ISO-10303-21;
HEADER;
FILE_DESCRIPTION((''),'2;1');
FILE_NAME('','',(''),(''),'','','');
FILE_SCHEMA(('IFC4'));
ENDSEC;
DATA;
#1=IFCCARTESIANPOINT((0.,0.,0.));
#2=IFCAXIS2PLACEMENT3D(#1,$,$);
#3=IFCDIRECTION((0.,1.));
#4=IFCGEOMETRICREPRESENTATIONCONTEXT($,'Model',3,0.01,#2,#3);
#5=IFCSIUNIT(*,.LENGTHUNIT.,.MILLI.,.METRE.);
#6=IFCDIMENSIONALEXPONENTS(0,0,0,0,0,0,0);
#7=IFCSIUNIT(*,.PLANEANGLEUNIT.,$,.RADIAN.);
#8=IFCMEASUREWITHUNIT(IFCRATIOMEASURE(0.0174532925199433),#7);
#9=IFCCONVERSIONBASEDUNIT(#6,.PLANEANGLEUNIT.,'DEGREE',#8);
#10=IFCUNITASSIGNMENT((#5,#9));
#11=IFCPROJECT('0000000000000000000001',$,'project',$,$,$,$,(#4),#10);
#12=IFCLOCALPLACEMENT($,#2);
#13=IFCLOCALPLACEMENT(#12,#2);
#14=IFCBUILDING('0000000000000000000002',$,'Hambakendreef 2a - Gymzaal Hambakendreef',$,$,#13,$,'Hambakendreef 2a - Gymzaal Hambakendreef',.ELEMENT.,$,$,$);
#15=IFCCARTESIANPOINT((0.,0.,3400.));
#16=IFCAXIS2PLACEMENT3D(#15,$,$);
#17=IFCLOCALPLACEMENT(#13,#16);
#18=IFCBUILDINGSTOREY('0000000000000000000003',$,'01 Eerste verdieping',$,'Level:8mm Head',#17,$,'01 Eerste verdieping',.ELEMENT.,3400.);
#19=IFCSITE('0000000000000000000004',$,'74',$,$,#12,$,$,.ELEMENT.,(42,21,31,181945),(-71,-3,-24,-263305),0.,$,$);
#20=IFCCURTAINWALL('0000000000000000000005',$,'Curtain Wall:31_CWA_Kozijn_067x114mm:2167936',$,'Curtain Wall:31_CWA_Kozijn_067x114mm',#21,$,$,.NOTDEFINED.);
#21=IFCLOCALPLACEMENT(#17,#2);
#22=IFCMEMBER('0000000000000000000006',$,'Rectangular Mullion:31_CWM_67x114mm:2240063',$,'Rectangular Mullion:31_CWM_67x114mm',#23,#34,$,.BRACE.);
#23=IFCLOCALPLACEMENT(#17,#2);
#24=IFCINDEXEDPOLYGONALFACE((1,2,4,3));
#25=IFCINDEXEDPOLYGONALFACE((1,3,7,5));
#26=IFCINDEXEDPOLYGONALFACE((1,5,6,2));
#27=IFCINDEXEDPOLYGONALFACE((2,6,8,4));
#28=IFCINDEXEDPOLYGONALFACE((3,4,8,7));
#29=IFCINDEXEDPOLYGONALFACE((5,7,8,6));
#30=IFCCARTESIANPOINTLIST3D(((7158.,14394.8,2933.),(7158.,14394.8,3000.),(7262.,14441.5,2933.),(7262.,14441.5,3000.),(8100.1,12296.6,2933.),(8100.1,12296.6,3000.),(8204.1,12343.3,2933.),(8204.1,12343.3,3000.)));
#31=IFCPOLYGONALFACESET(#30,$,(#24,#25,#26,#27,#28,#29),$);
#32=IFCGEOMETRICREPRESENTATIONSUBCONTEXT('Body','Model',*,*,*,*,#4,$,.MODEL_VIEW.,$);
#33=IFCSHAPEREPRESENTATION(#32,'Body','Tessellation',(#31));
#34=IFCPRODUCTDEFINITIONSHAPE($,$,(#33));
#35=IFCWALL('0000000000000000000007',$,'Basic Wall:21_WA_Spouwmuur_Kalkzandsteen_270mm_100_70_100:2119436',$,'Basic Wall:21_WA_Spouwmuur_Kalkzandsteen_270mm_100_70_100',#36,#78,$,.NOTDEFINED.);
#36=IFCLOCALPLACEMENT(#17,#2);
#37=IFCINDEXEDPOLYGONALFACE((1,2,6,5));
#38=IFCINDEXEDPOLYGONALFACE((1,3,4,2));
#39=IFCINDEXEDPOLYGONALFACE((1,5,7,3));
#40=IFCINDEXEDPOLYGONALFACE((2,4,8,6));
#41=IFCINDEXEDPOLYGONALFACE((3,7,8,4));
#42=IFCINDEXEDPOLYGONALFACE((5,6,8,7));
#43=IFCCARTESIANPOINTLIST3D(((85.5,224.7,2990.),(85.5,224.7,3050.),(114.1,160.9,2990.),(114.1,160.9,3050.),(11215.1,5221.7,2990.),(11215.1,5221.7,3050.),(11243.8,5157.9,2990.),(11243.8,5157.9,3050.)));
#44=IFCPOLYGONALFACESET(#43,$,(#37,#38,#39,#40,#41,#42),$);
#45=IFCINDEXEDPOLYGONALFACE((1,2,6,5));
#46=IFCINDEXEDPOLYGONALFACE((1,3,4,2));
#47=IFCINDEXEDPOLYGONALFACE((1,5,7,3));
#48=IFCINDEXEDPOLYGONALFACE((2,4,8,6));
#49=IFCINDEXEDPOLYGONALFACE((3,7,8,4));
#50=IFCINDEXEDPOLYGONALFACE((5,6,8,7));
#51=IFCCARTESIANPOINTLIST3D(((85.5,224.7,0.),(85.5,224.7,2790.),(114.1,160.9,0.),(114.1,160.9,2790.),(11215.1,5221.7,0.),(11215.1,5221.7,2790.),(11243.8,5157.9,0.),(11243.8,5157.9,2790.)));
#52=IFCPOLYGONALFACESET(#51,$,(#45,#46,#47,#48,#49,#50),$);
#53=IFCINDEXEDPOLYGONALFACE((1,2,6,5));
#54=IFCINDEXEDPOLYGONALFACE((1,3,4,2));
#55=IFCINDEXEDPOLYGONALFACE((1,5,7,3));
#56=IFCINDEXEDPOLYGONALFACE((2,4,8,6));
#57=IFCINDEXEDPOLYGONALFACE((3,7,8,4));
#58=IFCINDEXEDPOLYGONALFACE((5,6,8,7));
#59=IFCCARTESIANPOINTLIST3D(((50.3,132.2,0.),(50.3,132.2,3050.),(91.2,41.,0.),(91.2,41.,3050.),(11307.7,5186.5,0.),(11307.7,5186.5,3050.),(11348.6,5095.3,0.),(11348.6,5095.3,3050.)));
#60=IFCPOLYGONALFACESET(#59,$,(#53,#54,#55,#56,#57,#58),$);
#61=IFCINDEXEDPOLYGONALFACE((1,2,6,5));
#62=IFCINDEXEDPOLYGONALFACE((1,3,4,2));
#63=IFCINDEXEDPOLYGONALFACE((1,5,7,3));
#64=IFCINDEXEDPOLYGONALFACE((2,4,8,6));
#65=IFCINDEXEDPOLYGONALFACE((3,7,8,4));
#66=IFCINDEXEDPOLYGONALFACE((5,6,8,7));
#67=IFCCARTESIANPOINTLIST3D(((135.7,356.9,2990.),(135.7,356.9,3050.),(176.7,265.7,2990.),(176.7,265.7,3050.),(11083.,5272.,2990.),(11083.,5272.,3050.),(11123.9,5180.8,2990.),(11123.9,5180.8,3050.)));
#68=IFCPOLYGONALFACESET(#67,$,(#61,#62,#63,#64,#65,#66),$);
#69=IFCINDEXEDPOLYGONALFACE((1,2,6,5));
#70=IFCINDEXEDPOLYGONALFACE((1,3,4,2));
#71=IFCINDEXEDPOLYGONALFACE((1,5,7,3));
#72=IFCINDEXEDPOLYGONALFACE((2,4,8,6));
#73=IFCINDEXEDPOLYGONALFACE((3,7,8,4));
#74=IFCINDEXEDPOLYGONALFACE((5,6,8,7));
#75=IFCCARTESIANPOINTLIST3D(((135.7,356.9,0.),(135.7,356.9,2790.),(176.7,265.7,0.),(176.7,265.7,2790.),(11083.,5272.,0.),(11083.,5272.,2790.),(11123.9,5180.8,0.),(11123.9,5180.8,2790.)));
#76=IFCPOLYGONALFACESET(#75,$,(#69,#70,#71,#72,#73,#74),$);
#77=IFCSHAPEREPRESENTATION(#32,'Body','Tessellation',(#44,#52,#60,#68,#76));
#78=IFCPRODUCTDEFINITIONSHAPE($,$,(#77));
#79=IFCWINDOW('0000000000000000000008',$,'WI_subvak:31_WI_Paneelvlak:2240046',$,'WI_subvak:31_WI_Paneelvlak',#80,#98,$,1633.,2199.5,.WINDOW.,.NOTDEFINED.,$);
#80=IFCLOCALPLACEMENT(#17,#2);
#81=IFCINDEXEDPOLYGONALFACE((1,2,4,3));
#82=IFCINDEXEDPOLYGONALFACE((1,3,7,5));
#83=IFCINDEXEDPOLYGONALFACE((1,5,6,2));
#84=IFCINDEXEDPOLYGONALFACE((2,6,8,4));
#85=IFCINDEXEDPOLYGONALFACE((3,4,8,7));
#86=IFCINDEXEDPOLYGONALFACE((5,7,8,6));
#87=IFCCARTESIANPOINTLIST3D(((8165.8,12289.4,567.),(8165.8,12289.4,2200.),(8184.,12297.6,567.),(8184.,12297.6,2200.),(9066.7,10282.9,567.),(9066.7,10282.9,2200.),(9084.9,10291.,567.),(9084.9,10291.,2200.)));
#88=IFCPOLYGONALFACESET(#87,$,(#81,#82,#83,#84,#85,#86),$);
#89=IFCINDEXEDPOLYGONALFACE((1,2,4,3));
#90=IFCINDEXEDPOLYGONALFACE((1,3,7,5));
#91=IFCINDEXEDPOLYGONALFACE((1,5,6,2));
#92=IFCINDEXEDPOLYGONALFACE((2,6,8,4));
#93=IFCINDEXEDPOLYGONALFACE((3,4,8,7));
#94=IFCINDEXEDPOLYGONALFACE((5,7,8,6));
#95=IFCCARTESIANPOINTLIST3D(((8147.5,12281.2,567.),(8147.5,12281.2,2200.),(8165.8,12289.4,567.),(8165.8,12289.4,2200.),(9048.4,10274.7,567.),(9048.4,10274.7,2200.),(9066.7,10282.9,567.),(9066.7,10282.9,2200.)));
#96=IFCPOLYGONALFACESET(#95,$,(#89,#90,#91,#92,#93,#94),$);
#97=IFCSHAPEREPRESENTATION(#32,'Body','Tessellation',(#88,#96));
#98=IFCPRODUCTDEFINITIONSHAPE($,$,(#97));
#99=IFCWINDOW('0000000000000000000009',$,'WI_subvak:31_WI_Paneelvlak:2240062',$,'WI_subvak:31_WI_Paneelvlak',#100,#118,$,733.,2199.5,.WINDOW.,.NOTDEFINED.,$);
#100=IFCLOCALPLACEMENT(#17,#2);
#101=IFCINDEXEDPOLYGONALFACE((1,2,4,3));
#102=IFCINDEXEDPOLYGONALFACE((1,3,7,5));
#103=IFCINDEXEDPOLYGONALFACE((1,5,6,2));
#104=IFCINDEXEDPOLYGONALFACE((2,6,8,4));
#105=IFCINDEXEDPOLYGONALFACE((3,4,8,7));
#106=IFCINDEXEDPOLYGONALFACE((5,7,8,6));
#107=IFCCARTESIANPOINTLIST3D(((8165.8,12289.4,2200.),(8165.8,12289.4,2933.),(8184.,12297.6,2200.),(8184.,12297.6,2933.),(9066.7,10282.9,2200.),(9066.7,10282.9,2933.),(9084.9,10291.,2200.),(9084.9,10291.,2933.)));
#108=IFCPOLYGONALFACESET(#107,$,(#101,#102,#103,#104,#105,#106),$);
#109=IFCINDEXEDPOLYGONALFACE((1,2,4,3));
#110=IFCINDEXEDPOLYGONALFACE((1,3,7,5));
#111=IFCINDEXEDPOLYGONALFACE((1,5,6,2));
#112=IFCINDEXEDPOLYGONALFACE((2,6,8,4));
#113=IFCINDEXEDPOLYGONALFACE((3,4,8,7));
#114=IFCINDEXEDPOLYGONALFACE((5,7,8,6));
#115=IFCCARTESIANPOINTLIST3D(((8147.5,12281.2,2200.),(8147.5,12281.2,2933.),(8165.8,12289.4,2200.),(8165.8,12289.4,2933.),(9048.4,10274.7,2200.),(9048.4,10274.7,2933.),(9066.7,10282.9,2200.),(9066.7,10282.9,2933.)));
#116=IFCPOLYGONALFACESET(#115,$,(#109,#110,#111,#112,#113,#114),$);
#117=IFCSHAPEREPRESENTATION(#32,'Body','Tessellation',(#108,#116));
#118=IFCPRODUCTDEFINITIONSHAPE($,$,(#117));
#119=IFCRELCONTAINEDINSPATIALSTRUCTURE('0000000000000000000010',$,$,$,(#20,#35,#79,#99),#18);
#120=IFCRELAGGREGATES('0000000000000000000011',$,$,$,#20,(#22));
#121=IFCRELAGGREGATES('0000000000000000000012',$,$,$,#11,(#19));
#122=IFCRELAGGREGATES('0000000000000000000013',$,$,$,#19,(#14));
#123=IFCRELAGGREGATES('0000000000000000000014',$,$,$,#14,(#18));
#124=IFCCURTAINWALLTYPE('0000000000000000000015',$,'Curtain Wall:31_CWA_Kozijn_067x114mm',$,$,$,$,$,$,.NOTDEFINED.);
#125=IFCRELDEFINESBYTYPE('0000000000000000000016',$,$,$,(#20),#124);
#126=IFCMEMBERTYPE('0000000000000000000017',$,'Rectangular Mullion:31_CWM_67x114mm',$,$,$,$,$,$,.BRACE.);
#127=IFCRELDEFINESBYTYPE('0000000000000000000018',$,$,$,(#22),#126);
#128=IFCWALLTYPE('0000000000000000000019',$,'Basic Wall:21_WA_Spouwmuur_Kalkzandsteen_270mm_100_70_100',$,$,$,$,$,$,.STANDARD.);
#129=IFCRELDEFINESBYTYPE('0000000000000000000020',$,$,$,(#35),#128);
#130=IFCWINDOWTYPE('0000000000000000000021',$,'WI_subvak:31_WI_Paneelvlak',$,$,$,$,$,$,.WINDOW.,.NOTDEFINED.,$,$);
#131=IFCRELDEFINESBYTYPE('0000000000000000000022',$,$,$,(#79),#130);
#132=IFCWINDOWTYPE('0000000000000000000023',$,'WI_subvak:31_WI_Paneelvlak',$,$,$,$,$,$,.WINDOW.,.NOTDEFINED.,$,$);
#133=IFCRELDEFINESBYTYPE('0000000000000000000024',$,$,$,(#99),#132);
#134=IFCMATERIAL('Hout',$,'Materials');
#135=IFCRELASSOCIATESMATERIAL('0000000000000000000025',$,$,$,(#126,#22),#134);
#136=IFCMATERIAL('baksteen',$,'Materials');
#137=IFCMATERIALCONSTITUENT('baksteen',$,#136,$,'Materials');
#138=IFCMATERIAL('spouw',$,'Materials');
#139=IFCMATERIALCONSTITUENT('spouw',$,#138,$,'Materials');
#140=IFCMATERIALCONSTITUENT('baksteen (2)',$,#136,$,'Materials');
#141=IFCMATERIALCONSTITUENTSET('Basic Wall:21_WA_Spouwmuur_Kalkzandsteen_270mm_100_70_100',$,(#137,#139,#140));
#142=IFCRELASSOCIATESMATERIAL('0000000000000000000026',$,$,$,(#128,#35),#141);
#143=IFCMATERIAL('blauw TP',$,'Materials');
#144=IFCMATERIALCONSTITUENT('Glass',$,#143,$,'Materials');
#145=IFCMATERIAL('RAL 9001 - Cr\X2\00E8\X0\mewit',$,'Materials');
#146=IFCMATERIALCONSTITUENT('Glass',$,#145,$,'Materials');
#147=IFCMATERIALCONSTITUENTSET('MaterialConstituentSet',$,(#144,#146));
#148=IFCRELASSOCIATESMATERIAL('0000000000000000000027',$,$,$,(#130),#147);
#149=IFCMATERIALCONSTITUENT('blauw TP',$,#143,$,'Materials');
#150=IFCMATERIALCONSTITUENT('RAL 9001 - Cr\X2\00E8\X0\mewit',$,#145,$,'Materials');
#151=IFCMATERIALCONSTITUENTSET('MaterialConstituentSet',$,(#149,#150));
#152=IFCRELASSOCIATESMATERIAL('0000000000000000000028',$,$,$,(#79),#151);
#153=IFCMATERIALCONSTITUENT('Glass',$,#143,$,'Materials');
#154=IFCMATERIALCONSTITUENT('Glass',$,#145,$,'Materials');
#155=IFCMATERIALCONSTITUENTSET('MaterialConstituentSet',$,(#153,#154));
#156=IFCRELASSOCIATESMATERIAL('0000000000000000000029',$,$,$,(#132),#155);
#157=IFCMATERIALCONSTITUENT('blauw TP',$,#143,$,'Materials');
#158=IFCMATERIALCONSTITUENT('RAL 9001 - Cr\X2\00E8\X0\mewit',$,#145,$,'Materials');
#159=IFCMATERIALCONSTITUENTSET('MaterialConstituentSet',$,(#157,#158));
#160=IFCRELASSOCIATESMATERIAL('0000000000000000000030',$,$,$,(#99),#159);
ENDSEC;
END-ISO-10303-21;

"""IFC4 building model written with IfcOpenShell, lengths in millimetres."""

from ifc_helpers import new_model, entity, si_unit, converted_unit, direction, frame, origin, place, context, subcontext, project, spatial, indexed_curve, outline, extrude, source, transform, mapped, material, constituent, constituent_set, type_object, type_shapes, element, aggregate, save


model = new_model("IFC4")

# Units and contexts
model_context = context("Model", 3, precision=0.01, world=origin(), true_north=direction((0.0, 1.0)))
body_context = subcontext(model_context, "Body", "Model", "MODEL_VIEW")
ifc_project = project(units=[si_unit("LENGTHUNIT", "METRE", prefix="MILLI"), converted_unit("PLANEANGLEUNIT", "DEGREE", entity("IfcRatioMeasure", 0.0174532925199433), si_unit("PLANEANGLEUNIT", "RADIAN"), dimensions=[0, 0, 0, 0, 0, 0, 0])], contexts=[model_context])

# Site, building, storey
site_placement = place(None, origin())
site = spatial("IfcSite", under=ifc_project, at=site_placement, Name="74", CompositionType="ELEMENT", RefLatitude=(42, 21, 31, 181945), RefLongitude=(-71, -3, -24, -263305), RefElevation=0.0)
building_placement = place(site_placement, origin())
building = spatial("IfcBuilding", under=site, at=building_placement, Name="Hambakendreef 2a - Gymzaal Hambakendreef", LongName="Hambakendreef 2a - Gymzaal Hambakendreef", CompositionType="ELEMENT")
storey_placement = place(building_placement, frame((0.0, 0.0, 3400.0)))
storey = spatial("IfcBuildingStorey", under=building, at=storey_placement, Name="01 Eerste verdieping", ObjectType="Level:8mm Head", LongName="01 Eerste verdieping", CompositionType="ELEMENT", Elevation=3400.0)

# Curtain wall, member
curtain_wall_type = type_object("IfcCurtainWallType", Name="Curtain Wall:31_CWA_Kozijn_067x114mm", PredefinedType="NOTDEFINED")
ifc_material_1 = material(Name="Hout", Category="Materials")
curtain_wall_1_placement = place(storey_placement, frame((0.0, 0.0, -3400.0)))
curtain_wall_1 = element("IfcCurtainWall", 1, at=curtain_wall_1_placement, inside=storey, type_object=curtain_wall_type, Name="Curtain Wall:31_CWA_Kozijn_067x114mm:2167936", ObjectType="Curtain Wall:31_CWA_Kozijn_067x114mm", PredefinedType="NOTDEFINED")
member_type_1 = type_object("IfcMemberType", Name="Rectangular Mullion:31_CWM_67x114mm", PredefinedType="BRACE", material=ifc_material_1)
shared_shape_1 = source(origin(), body_context, "Body", "SweptSolid", [
    extrude(outline(indexed_curve([(-57.0, -33.5), (57.0, -33.5), (57.0, 33.5), (-57.0, 33.5), (-57.0, -33.5)], self_intersect=False)), frame((-33.5, 0.0, -2300.0), z_axis=(0.0, 0.0, 1.0), x_axis=(0.0, -1.0, 0.0)), (0.0, 0.0, 1.0), 2300.0),
])
type_shapes(member_type_1, [shared_shape_1])
member_1_placement = place(storey_placement, frame((8152.1, 12319.9, 3000.0), z_axis=(0.40959, -0.91227, 0.0), x_axis=(0.0, 0.0, 1.0)))
member_1 = element("IfcMember", 2, at=member_1_placement, type_object=member_type_1, material=ifc_material_1, Name="Rectangular Mullion:31_CWM_67x114mm:2240063", ObjectType="Rectangular Mullion:31_CWM_67x114mm", PredefinedType="BRACE", context=body_context, shape_type="MappedRepresentation", body=[
    mapped(shared_shape_1, transform((0.0, 0.0, 0.0), scale=1.0)),
])
aggregate(curtain_wall_1, [member_1])

# Wall
ifc_material_2 = material(Name="baksteen", Category="Materials")
ifc_constituent_1 = constituent(ifc_material_2, Name="baksteen", Category="Materials")
ifc_material_3 = material(Name="spouw", Category="Materials")
ifc_constituent_2 = constituent(ifc_material_3, Name="spouw", Category="Materials")
ifc_constituent_3 = constituent(ifc_material_2, Name="baksteen (2)", Category="Materials")
ifc_constituent_set_1 = constituent_set(constituents=[ifc_constituent_1, ifc_constituent_2, ifc_constituent_3], Name="Basic Wall:21_WA_Spouwmuur_Kalkzandsteen_270mm_100_70_100")
wall_type = type_object("IfcWallType", Name="Basic Wall:21_WA_Spouwmuur_Kalkzandsteen_270mm_100_70_100", PredefinedType="STANDARD", material=ifc_constituent_set_1)
wall_placement = place(storey_placement, frame((11138.3, 5148.8, 0.0), z_axis=(0.0, 0.0, 1.0), x_axis=(-0.91227, -0.40959, 0.0)))
element("IfcWall", 3, at=wall_placement, inside=storey, type_object=wall_type, material=ifc_constituent_set_1, Name="Basic Wall:21_WA_Spouwmuur_Kalkzandsteen_270mm_100_70_100:2119436", ObjectType="Basic Wall:21_WA_Spouwmuur_Kalkzandsteen_270mm_100_70_100", PredefinedType="NOTDEFINED", context=body_context, shape_type="SweptSolid", body=[
    extrude(outline(indexed_curve([(-6100.0, -35.0), (6100.0, -35.0), (6100.0, 35.0), (-6100.0, 35.0), (-6100.0, -35.0)], self_intersect=False)), frame((6000.0, 0.0, 2990.0), z_axis=(0.0, 0.0, 1.0), x_axis=(-1.0, 0.0, 0.0)), (0.0, 0.0, 1.0), 60.0),
    extrude(outline(indexed_curve([(-6100.0, -35.0), (6100.0, -35.0), (6100.0, 35.0), (-6100.0, 35.0), (-6100.0, -35.0)], self_intersect=False)), frame((6000.0, 0.0, 0.0)), (0.0, 0.0, 1.0), 2790.0),
    extrude(outline(indexed_curve([(-50.0, -6170.0), (50.0, -6170.0), (50.0, 6170.0), (-50.0, 6170.0), (-50.0, -6170.0)], self_intersect=False)), frame((6000.0, 85.0, 0.0), z_axis=(0.0, 0.0, 1.0), x_axis=(0.0, -1.0, 0.0)), (0.0, 0.0, 1.0), 3050.0),
    extrude(outline(indexed_curve([(-50.0, -6000.0), (50.0, -6000.0), (50.0, 6000.0), (-50.0, 6000.0), (-50.0, -6000.0)], self_intersect=False)), frame((6000.0, -85.0, 2990.0), z_axis=(0.0, 0.0, 1.0), x_axis=(0.0, 1.0, 0.0)), (0.0, 0.0, 1.0), 60.0),
    extrude(outline(indexed_curve([(-50.0, -6000.0), (50.0, -6000.0), (50.0, 6000.0), (-50.0, 6000.0), (-50.0, -6000.0)], self_intersect=False)), frame((6000.0, -85.0, 0.0), z_axis=(0.0, 0.0, 1.0), x_axis=(0.0, 1.0, 0.0)), (0.0, 0.0, 1.0), 2790.0),
])

# Windows
ifc_material_4 = material(Name="blauw TP", Category="Materials")
ifc_constituent_4 = constituent(ifc_material_4, Name="blauw TP", Category="Materials")
ifc_material_5 = material(Name="RAL 9001 - Crèmewit", Category="Materials")
ifc_constituent_5 = constituent(ifc_material_5, Name="RAL 9001 - Crèmewit", Category="Materials")
ifc_constituent_set_2 = constituent_set(constituents=[ifc_constituent_4, ifc_constituent_5], Name="MaterialConstituentSet")
ifc_constituent_6 = constituent(ifc_material_4, Name="Glass", Category="Materials")
ifc_constituent_7 = constituent(ifc_material_5, Name="Glass", Category="Materials")
ifc_constituent_set_3 = constituent_set(constituents=[ifc_constituent_6, ifc_constituent_7], Name="MaterialConstituentSet")
window_type_1 = type_object("IfcWindowType", Name="WI_subvak:31_WI_Paneelvlak", PartitioningType="NOTDEFINED", PredefinedType="WINDOW", material=ifc_constituent_set_3)
shared_shape_2 = source(origin(), body_context, "Body", "SweptSolid", [
    extrude(outline(indexed_curve([(-10.0, -1099.8), (10.0, -1099.8), (10.0, 1099.8), (-10.0, 1099.8), (-10.0, -1099.8)], self_intersect=False)), frame((0.0, 10.0, 0.0), z_axis=(0.0, 0.0, 1.0), x_axis=(0.0, -1.0, 0.0)), (0.0, 0.0, 1.0), 1633.0),
    extrude(outline(indexed_curve([(-10.0, -1099.8), (10.0, -1099.8), (10.0, 1099.8), (-10.0, 1099.8), (-10.0, -1099.8)], self_intersect=False)), frame((0.0, -10.0, 0.0), z_axis=(0.0, 0.0, 1.0), x_axis=(0.0, -1.0, 0.0)), (0.0, 0.0, 1.0), 1633.0),
])
type_shapes(window_type_1, [shared_shape_2])
window_1_placement = place(storey_placement, frame((8616.2, 11286.1, 567.0), z_axis=(0.0, 0.0, 1.0), x_axis=(0.40959, -0.91227, 0.0)))
element("IfcWindow", 4, at=window_1_placement, inside=storey, type_object=window_type_1, material=ifc_constituent_set_2, Name="WI_subvak:31_WI_Paneelvlak:2240046", ObjectType="WI_subvak:31_WI_Paneelvlak", OverallHeight=1633.0, OverallWidth=2199.5, PartitioningType="NOTDEFINED", PredefinedType="WINDOW", context=body_context, shape_type="MappedRepresentation", body=[
    mapped(shared_shape_2, transform((0.0, 0.0, 0.0), scale=1.0)),
])
ifc_constituent_8 = constituent(ifc_material_4, Name="blauw TP", Category="Materials")
ifc_constituent_9 = constituent(ifc_material_5, Name="RAL 9001 - Crèmewit", Category="Materials")
ifc_constituent_set_4 = constituent_set(constituents=[ifc_constituent_8, ifc_constituent_9], Name="MaterialConstituentSet")
ifc_constituent_10 = constituent(ifc_material_4, Name="Glass", Category="Materials")
ifc_constituent_11 = constituent(ifc_material_5, Name="Glass", Category="Materials")
ifc_constituent_set_5 = constituent_set(constituents=[ifc_constituent_10, ifc_constituent_11], Name="MaterialConstituentSet")
window_type_2 = type_object("IfcWindowType", Name="WI_subvak:31_WI_Paneelvlak", PartitioningType="NOTDEFINED", PredefinedType="WINDOW", material=ifc_constituent_set_5)
shared_shape_3 = source(origin(), body_context, "Body", "SweptSolid", [
    extrude(outline(indexed_curve([(-10.0, -1099.8), (10.0, -1099.8), (10.0, 1099.8), (-10.0, 1099.8), (-10.0, -1099.8)], self_intersect=False)), frame((0.0, 10.0, 0.0), z_axis=(0.0, 0.0, 1.0), x_axis=(0.0, -1.0, 0.0)), (0.0, 0.0, 1.0), 733.0),
    extrude(outline(indexed_curve([(-10.0, -1099.8), (10.0, -1099.8), (10.0, 1099.8), (-10.0, 1099.8), (-10.0, -1099.8)], self_intersect=False)), frame((0.0, -10.0, 0.0), z_axis=(0.0, 0.0, 1.0), x_axis=(0.0, -1.0, 0.0)), (0.0, 0.0, 1.0), 733.0),
])
type_shapes(window_type_2, [shared_shape_3])
window_2_placement = place(storey_placement, frame((8616.2, 11286.1, 2200.0), z_axis=(0.0, 0.0, 1.0), x_axis=(0.40959, -0.91227, 0.0)))
element("IfcWindow", 5, at=window_2_placement, inside=storey, type_object=window_type_2, material=ifc_constituent_set_4, Name="WI_subvak:31_WI_Paneelvlak:2240062", ObjectType="WI_subvak:31_WI_Paneelvlak", OverallHeight=733.0, OverallWidth=2199.5, PartitioningType="NOTDEFINED", PredefinedType="WINDOW", context=body_context, shape_type="MappedRepresentation", body=[
    mapped(shared_shape_3, transform((0.0, 0.0, 0.0), scale=1.0)),
])

save(model, "model.ifc")
